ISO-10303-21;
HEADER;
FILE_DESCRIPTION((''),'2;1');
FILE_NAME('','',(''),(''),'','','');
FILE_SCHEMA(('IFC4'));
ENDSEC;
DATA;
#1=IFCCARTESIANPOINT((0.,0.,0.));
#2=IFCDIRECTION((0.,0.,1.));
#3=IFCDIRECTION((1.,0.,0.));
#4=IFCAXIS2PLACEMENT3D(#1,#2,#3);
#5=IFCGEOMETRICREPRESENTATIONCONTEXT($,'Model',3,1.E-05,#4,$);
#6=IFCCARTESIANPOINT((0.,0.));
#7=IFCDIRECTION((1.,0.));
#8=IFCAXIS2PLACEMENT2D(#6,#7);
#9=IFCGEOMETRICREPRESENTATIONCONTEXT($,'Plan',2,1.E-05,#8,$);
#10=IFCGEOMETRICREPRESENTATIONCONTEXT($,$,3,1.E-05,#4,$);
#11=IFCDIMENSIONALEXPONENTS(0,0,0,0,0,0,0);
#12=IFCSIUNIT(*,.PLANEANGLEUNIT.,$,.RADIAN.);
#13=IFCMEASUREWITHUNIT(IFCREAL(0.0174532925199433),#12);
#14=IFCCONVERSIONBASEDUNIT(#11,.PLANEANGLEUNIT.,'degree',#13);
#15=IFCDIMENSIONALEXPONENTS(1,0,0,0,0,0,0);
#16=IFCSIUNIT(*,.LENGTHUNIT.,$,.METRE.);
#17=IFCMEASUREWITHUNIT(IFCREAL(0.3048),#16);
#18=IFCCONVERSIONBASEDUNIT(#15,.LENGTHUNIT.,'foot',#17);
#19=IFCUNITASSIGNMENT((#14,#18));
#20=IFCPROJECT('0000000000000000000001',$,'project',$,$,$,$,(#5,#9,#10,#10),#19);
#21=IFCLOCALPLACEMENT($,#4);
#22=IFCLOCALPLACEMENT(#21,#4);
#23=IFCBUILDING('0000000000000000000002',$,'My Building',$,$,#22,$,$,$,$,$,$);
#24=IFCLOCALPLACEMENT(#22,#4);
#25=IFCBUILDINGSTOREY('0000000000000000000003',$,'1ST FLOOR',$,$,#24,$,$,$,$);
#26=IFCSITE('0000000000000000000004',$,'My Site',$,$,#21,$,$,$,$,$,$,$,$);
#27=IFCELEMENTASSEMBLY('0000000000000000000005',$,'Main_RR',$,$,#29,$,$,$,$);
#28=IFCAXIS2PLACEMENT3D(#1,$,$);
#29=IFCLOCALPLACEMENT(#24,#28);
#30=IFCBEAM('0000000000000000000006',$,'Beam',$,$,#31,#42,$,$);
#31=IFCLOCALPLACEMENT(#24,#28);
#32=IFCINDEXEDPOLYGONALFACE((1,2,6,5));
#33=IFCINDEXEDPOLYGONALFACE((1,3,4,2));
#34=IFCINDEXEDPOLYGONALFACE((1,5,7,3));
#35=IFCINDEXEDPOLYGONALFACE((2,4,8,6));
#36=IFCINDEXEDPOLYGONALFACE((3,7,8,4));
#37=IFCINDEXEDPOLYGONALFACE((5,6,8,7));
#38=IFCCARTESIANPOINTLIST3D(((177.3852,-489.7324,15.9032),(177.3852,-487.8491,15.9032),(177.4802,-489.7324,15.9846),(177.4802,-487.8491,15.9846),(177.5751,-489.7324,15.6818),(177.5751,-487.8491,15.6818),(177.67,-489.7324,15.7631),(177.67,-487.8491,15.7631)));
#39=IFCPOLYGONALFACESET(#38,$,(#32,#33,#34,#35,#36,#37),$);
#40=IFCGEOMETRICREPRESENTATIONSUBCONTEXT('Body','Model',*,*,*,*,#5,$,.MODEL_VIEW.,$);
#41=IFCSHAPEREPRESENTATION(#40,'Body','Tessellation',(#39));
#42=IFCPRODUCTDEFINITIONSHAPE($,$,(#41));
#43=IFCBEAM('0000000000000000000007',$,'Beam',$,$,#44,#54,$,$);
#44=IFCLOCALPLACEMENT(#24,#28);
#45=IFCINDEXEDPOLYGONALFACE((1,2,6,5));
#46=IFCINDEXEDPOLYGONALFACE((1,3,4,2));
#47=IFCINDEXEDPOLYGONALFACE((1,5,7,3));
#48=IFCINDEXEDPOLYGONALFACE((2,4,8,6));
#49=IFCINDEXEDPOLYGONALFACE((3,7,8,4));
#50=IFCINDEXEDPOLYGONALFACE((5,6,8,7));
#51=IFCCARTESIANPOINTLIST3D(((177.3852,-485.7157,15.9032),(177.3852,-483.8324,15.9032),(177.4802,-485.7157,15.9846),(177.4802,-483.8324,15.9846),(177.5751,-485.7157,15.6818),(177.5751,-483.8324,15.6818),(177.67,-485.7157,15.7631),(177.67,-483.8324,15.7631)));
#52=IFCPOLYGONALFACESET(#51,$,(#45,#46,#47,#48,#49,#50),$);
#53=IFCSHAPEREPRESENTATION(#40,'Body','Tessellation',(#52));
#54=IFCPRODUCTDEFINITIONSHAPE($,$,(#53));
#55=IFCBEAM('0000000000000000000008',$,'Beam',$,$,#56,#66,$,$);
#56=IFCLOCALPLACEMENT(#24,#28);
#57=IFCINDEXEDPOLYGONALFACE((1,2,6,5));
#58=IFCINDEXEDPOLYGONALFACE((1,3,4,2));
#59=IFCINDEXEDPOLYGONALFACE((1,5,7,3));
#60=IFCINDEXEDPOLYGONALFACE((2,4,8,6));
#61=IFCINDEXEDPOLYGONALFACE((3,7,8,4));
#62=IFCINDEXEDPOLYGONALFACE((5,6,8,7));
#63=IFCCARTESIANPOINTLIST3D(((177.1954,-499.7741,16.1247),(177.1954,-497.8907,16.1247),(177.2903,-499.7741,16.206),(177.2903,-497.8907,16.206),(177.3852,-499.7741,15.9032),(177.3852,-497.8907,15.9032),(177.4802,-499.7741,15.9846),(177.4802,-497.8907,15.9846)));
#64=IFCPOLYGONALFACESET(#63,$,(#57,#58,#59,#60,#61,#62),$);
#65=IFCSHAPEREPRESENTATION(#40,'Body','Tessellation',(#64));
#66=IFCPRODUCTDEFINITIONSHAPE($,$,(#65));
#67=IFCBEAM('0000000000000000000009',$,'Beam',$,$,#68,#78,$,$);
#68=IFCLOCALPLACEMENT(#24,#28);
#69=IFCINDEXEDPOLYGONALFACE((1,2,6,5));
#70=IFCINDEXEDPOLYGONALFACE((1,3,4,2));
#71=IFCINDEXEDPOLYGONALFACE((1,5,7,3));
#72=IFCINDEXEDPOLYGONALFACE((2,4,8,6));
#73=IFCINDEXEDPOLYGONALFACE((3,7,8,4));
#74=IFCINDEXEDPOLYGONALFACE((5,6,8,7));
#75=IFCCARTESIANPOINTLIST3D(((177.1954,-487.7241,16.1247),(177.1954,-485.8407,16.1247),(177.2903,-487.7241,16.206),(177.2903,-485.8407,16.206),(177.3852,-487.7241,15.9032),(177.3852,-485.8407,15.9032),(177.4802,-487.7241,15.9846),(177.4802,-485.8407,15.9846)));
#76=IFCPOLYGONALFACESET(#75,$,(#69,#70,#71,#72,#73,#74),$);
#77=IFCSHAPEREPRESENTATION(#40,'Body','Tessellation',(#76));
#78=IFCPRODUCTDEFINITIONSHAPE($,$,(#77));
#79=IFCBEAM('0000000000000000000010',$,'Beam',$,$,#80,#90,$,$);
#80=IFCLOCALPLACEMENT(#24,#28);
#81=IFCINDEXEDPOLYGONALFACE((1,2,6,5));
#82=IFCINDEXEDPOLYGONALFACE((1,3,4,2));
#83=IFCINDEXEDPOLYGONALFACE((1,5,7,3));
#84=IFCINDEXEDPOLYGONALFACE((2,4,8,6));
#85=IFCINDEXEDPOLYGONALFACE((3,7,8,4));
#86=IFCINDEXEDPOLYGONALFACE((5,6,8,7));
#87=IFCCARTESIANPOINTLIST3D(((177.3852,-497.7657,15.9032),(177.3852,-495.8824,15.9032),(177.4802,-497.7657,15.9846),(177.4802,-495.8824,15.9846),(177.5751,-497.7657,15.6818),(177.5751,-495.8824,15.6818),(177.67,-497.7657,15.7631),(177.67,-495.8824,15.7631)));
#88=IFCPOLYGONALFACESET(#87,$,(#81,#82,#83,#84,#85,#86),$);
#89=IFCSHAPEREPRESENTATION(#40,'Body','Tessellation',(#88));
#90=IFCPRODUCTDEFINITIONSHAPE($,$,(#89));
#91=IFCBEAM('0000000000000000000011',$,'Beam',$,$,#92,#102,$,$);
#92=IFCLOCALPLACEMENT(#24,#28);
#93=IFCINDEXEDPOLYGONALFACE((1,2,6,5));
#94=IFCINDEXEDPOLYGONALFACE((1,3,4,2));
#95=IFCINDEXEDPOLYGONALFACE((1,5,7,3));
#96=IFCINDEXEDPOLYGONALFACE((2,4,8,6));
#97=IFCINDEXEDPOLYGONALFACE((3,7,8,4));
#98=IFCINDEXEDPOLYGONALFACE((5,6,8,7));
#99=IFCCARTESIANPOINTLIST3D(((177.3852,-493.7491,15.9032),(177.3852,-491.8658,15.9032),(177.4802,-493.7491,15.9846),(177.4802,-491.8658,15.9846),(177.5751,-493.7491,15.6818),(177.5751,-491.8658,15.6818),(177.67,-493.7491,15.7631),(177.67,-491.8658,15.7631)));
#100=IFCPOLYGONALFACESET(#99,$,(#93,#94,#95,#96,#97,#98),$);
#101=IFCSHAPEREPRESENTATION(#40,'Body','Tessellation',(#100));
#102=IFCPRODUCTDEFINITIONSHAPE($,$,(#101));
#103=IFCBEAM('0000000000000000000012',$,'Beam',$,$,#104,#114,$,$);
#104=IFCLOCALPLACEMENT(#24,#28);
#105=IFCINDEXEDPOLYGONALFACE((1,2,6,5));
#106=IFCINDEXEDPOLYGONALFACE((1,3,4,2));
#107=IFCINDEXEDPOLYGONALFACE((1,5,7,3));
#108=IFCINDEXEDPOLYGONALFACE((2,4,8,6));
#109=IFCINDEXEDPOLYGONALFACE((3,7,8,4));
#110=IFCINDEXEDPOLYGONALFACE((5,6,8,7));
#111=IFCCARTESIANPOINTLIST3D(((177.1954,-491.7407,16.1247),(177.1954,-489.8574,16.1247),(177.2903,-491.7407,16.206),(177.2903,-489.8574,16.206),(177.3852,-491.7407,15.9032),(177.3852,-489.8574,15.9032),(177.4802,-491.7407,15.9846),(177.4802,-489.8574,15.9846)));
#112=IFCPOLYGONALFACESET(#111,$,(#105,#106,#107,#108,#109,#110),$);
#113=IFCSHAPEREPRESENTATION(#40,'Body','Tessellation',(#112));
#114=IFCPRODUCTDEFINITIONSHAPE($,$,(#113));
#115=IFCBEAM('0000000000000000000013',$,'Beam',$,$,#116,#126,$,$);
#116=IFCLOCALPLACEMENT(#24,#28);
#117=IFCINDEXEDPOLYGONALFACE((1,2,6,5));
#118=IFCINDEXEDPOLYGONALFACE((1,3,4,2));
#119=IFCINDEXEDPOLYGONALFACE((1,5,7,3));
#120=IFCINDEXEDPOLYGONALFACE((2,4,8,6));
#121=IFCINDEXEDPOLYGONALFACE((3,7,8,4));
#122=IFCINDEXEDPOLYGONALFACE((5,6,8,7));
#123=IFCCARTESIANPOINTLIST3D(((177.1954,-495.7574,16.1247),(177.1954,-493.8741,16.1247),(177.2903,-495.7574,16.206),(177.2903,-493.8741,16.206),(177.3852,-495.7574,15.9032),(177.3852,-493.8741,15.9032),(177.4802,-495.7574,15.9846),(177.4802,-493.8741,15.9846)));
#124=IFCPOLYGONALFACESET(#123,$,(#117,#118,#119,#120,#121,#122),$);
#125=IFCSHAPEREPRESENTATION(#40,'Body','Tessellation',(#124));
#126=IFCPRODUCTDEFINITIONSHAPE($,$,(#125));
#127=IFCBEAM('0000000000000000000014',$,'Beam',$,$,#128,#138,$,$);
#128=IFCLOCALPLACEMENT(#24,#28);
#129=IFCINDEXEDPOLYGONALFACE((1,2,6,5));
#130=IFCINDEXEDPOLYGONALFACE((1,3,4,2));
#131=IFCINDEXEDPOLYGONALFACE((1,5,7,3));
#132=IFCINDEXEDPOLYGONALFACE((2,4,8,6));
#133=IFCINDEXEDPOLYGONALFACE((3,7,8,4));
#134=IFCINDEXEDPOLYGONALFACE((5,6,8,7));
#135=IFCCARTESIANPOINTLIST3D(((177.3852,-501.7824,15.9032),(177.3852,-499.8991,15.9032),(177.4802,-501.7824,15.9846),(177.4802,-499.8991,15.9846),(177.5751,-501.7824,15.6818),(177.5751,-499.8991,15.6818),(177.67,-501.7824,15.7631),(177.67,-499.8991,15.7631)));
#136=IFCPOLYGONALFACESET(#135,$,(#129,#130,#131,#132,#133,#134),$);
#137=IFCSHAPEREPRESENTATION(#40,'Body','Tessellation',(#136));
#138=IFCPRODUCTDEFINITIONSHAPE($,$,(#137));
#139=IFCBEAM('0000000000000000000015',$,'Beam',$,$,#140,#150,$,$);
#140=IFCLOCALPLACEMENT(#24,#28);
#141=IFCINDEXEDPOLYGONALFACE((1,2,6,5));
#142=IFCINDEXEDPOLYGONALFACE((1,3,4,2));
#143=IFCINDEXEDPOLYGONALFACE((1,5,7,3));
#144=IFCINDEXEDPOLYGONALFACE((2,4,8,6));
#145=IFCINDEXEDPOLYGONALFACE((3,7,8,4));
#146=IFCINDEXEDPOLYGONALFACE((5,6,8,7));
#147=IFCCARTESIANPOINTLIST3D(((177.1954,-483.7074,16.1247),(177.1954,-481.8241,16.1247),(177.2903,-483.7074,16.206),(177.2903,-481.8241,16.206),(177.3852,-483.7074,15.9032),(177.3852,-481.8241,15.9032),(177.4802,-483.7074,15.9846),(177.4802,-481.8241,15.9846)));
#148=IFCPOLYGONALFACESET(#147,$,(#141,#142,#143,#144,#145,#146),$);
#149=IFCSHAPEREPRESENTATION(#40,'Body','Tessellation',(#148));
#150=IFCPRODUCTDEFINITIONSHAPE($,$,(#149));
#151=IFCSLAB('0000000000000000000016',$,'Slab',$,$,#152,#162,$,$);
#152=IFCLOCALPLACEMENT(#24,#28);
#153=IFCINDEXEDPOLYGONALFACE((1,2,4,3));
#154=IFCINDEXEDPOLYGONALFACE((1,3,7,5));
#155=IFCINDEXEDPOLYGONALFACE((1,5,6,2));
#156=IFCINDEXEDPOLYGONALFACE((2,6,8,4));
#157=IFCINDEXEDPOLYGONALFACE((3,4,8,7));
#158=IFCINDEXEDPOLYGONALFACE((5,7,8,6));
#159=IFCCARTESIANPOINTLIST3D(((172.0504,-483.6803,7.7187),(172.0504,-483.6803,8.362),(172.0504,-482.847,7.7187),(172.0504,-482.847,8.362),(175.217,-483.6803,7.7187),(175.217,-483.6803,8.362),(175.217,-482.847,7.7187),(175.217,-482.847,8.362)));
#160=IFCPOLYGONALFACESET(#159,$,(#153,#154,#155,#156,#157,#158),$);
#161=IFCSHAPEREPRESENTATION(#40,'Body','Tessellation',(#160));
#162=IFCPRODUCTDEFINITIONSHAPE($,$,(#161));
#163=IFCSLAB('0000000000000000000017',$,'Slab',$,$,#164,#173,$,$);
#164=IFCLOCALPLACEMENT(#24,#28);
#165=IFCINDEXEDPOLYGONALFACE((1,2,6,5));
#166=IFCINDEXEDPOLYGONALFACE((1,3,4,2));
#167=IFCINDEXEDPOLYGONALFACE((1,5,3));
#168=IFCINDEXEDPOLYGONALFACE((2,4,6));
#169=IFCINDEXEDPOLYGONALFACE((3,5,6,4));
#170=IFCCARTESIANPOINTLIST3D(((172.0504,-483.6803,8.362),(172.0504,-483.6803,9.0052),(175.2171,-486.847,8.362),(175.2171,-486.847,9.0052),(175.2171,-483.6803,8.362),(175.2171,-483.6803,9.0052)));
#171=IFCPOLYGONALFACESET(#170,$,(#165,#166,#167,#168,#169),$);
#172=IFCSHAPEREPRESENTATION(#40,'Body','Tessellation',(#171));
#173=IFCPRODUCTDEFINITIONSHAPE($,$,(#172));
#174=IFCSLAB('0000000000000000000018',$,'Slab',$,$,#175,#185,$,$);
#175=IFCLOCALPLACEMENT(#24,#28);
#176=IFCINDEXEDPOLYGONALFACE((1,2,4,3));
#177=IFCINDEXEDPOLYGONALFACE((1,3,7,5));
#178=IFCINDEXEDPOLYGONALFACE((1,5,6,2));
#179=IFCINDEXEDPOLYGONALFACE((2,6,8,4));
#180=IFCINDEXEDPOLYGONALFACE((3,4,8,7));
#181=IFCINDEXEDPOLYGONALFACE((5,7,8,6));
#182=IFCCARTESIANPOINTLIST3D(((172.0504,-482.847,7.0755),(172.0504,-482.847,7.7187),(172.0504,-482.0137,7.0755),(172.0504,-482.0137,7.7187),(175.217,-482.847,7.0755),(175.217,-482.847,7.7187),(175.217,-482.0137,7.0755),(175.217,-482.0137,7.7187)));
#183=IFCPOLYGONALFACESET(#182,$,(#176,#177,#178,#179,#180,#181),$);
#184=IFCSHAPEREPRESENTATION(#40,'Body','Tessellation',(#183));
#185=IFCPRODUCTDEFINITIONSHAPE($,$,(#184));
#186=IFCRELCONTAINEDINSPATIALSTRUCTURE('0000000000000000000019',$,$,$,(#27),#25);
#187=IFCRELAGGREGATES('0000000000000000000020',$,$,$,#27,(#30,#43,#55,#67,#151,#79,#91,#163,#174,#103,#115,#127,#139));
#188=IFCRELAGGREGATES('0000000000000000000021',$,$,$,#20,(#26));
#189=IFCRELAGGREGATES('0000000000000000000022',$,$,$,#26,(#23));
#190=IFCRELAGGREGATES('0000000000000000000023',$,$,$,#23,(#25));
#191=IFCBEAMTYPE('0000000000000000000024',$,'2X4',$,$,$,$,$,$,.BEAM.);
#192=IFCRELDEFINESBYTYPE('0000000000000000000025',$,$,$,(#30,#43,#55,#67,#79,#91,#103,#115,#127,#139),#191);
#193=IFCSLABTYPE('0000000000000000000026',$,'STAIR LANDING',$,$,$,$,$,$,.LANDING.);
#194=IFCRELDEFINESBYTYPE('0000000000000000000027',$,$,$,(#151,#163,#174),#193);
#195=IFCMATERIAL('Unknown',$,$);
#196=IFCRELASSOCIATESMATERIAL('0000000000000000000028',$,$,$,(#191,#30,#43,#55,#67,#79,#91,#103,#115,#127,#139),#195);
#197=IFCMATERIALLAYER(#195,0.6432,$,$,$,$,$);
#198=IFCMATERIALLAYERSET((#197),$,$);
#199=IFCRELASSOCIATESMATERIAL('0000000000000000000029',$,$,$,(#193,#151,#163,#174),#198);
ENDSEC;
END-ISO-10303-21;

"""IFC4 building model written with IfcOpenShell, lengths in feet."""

from ifc_helpers import new_model, entity, si_unit, converted_unit, frame, origin_with_axes, origin_2d_with_axis, place, context, subcontext, project, spatial, line, indexed_curve, rectangle, outline, extrude, material, layer, layer_set, layer_usage, material_profile, profile_set, profile_usage, type_object, element, aggregate, save


model = new_model("IFC4")

# Units and contexts
model_context = context("Model", 3, precision=1e-05, world=origin_with_axes())
plan_context = context("Plan", 2, precision=1e-05, world=origin_2d_with_axis())
context_of_model = context(None, 3, precision=1e-05, world=origin_with_axes())
body_context = subcontext(model_context, "Body", "Model", "MODEL_VIEW")
ifc_project = project(units=[converted_unit("PLANEANGLEUNIT", "degree", entity("IfcReal", 0.0174532925199433), si_unit("PLANEANGLEUNIT", "RADIAN"), dimensions=[0, 0, 0, 0, 0, 0, 0]), converted_unit("LENGTHUNIT", "foot", entity("IfcReal", 0.3048), si_unit("LENGTHUNIT", "METRE"), dimensions=[1, 0, 0, 0, 0, 0, 0])], contexts=[model_context, plan_context, context_of_model, context_of_model])

# Site, building, storey
site_placement = place(None, origin_with_axes())
site = spatial("IfcSite", under=ifc_project, at=site_placement, Name="My Site")
building_placement = place(site_placement, origin_with_axes())
building = spatial("IfcBuilding", under=site, at=building_placement, Name="My Building")
storey_placement = place(building_placement, origin_with_axes())
storey = spatial("IfcBuildingStorey", under=building, at=storey_placement, Name="1ST FLOOR")

# Element assembly, beams, slabs
assembly_placement = place(storey_placement, origin_with_axes())
assembly = element("IfcElementAssembly", 1, at=assembly_placement, inside=storey, Name="Main_RR")
ifc_material_1 = material(Name="Unknown")
ifc_material_profile = material_profile(ifc_material_1, rectangle(XDim=0.125, YDim=0.2917))
ifc_profile_set = profile_set([ifc_material_profile])
ifc_profile_usage_1 = profile_usage(ifc_profile_set, cardinal=5)
beam_type = type_object("IfcBeamType", Name="2X4", PredefinedType="BEAM", material=ifc_profile_set)
beam_1_placement = place(assembly_placement, frame((177.5276, -487.8491, 15.8332), z_axis=(0.0, -1.0, 0.0), x_axis=(-0.759271, 0.0, -0.650774)))
beam_1 = element("IfcBeam", 2, at=beam_1_placement, type_object=beam_type, material=ifc_profile_usage_1, Name="Beam", context=body_context, shape_type="SweptSolid", body=[
    extrude(rectangle(XDim=0.125, YDim=0.2917), origin_with_axes(), (0.0, 0.0, 1.0), 1.8833),
])
ifc_profile_usage_2 = profile_usage(ifc_profile_set, cardinal=5)
beam_2_placement = place(assembly_placement, frame((177.5276, -483.8324, 15.8332), z_axis=(0.0, -1.0, 0.0), x_axis=(-0.759271, 0.0, -0.650774)))
beam_2 = element("IfcBeam", 3, at=beam_2_placement, type_object=beam_type, material=ifc_profile_usage_2, Name="Beam", context=body_context, shape_type="SweptSolid", body=[
    extrude(rectangle(XDim=0.125, YDim=0.2917), origin_with_axes(), (0.0, 0.0, 1.0), 1.8833),
])
ifc_profile_usage_3 = profile_usage(ifc_profile_set, cardinal=5)
beam_3_placement = place(assembly_placement, frame((177.3378, -497.8907, 16.0546), z_axis=(0.0, -1.0, 0.0), x_axis=(-0.759271, 0.0, -0.650774)))
beam_3 = element("IfcBeam", 4, at=beam_3_placement, type_object=beam_type, material=ifc_profile_usage_3, Name="Beam", context=body_context, shape_type="SweptSolid", body=[
    extrude(rectangle(XDim=0.125, YDim=0.2917), origin_with_axes(), (0.0, 0.0, 1.0), 1.8833),
])
ifc_profile_usage_4 = profile_usage(ifc_profile_set, cardinal=5)
beam_4_placement = place(assembly_placement, frame((177.3378, -485.8407, 16.0546), z_axis=(0.0, -1.0, 0.0), x_axis=(-0.759271, 0.0, -0.650774)))
beam_4 = element("IfcBeam", 5, at=beam_4_placement, type_object=beam_type, material=ifc_profile_usage_4, Name="Beam", context=body_context, shape_type="SweptSolid", body=[
    extrude(rectangle(XDim=0.125, YDim=0.2917), origin_with_axes(), (0.0, 0.0, 1.0), 1.8833),
])
ifc_profile_usage_5 = profile_usage(ifc_profile_set, cardinal=5)
beam_5_placement = place(assembly_placement, frame((177.5276, -495.8824, 15.8332), z_axis=(0.0, -1.0, 0.0), x_axis=(-0.759271, 0.0, -0.650774)))
beam_5 = element("IfcBeam", 6, at=beam_5_placement, type_object=beam_type, material=ifc_profile_usage_5, Name="Beam", context=body_context, shape_type="SweptSolid", body=[
    extrude(rectangle(XDim=0.125, YDim=0.2917), origin_with_axes(), (0.0, 0.0, 1.0), 1.8833),
])
ifc_profile_usage_6 = profile_usage(ifc_profile_set, cardinal=5)
beam_6_placement = place(assembly_placement, frame((177.5276, -491.8658, 15.8332), z_axis=(0.0, -1.0, 0.0), x_axis=(-0.759271, 0.0, -0.650774)))
beam_6 = element("IfcBeam", 7, at=beam_6_placement, type_object=beam_type, material=ifc_profile_usage_6, Name="Beam", context=body_context, shape_type="SweptSolid", body=[
    extrude(rectangle(XDim=0.125, YDim=0.2917), origin_with_axes(), (0.0, 0.0, 1.0), 1.8833),
])
ifc_profile_usage_7 = profile_usage(ifc_profile_set, cardinal=5)
beam_7_placement = place(assembly_placement, frame((177.3378, -489.8574, 16.0546), z_axis=(0.0, -1.0, 0.0), x_axis=(-0.759271, 0.0, -0.650774)))
beam_7 = element("IfcBeam", 8, at=beam_7_placement, type_object=beam_type, material=ifc_profile_usage_7, Name="Beam", context=body_context, shape_type="SweptSolid", body=[
    extrude(rectangle(XDim=0.125, YDim=0.2917), origin_with_axes(), (0.0, 0.0, 1.0), 1.8833),
])
ifc_profile_usage_8 = profile_usage(ifc_profile_set, cardinal=5)
beam_8_placement = place(assembly_placement, frame((177.3378, -493.8741, 16.0546), z_axis=(0.0, -1.0, 0.0), x_axis=(-0.759271, 0.0, -0.650774)))
beam_8 = element("IfcBeam", 9, at=beam_8_placement, type_object=beam_type, material=ifc_profile_usage_8, Name="Beam", context=body_context, shape_type="SweptSolid", body=[
    extrude(rectangle(XDim=0.125, YDim=0.2917), origin_with_axes(), (0.0, 0.0, 1.0), 1.8833),
])
ifc_profile_usage_9 = profile_usage(ifc_profile_set, cardinal=5)
beam_9_placement = place(assembly_placement, frame((177.5276, -499.8991, 15.8332), z_axis=(0.0, -1.0, 0.0), x_axis=(-0.759271, 0.0, -0.650774)))
beam_9 = element("IfcBeam", 10, at=beam_9_placement, type_object=beam_type, material=ifc_profile_usage_9, Name="Beam", context=body_context, shape_type="SweptSolid", body=[
    extrude(rectangle(XDim=0.125, YDim=0.2917), origin_with_axes(), (0.0, 0.0, 1.0), 1.8833),
])
ifc_profile_usage_10 = profile_usage(ifc_profile_set, cardinal=5)
beam_10_placement = place(assembly_placement, frame((177.3378, -481.8241, 16.0546), z_axis=(0.0, -1.0, 0.0), x_axis=(-0.759271, 0.0, -0.650774)))
beam_10 = element("IfcBeam", 11, at=beam_10_placement, type_object=beam_type, material=ifc_profile_usage_10, Name="Beam", context=body_context, shape_type="SweptSolid", body=[
    extrude(rectangle(XDim=0.125, YDim=0.2917), origin_with_axes(), (0.0, 0.0, 1.0), 1.8833),
])
ifc_layer_1 = layer(ifc_material_1, 0.6432)
ifc_layer_set_1 = layer_set([ifc_layer_1])
ifc_layer_usage_1 = layer_usage(ifc_layer_set_1, "AXIS3", "POSITIVE", 0.0)
slab_type = type_object("IfcSlabType", Name="STAIR LANDING", PredefinedType="LANDING", material=ifc_layer_set_1)
slab_1_placement = place(assembly_placement, frame((172.0504, -482.847, 7.7187), z_axis=(0.0, 0.0, 1.0), x_axis=(1.0, 0.0, 0.0)))
slab_1 = element("IfcSlab", 12, at=slab_1_placement, type_object=slab_type, material=ifc_layer_usage_1, Name="Slab", context=body_context, shape_type="SweptSolid", body=[
    extrude(outline(indexed_curve([(3.1667, -0.8333), (0.0, -0.8333), (0.0, 0.0), (3.1667, 0.0)], segments=[line(4, 1), line(1, 2), line(2, 3), line(3, 4)], self_intersect=False)), None, (0.0, 0.0, 1.0), 0.6432),
])
ifc_layer_usage_2 = layer_usage(ifc_layer_set_1, "AXIS3", "POSITIVE", 0.0)
slab_2_placement = place(assembly_placement, frame((172.0504, -486.847, 8.362), z_axis=(0.0, 0.0, 1.0), x_axis=(1.0, 0.0, 0.0)))
slab_2 = element("IfcSlab", 13, at=slab_2_placement, type_object=slab_type, material=ifc_layer_usage_2, Name="Slab", context=body_context, shape_type="SweptSolid", body=[
    extrude(outline(indexed_curve([(0.0, 3.1667), (3.1667, 0.0), (3.1667, 3.1667)], segments=[line(2, 3), line(3, 1), line(1, 2)], self_intersect=False)), None, (0.0, 0.0, 1.0), 0.6432),
])
ifc_layer_usage_3 = layer_usage(ifc_layer_set_1, "AXIS3", "POSITIVE", 0.0)
slab_3_placement = place(assembly_placement, frame((172.0504, -482.0137, 7.0755), z_axis=(0.0, 0.0, 1.0), x_axis=(1.0, 0.0, 0.0)))
slab_3 = element("IfcSlab", 14, at=slab_3_placement, type_object=slab_type, material=ifc_layer_usage_3, Name="Slab", context=body_context, shape_type="SweptSolid", body=[
    extrude(outline(indexed_curve([(3.1667, -0.8333), (0.0, -0.8333), (0.0, 0.0), (3.1667, 0.0)], segments=[line(4, 1), line(1, 2), line(2, 3), line(3, 4)], self_intersect=False)), None, (0.0, 0.0, 1.0), 0.6432),
])
aggregate(assembly, [beam_1, beam_2, beam_3, beam_4, slab_1, beam_5, beam_6, slab_2, slab_3, beam_7, beam_8, beam_9, beam_10])

save(model, "model.ifc")
